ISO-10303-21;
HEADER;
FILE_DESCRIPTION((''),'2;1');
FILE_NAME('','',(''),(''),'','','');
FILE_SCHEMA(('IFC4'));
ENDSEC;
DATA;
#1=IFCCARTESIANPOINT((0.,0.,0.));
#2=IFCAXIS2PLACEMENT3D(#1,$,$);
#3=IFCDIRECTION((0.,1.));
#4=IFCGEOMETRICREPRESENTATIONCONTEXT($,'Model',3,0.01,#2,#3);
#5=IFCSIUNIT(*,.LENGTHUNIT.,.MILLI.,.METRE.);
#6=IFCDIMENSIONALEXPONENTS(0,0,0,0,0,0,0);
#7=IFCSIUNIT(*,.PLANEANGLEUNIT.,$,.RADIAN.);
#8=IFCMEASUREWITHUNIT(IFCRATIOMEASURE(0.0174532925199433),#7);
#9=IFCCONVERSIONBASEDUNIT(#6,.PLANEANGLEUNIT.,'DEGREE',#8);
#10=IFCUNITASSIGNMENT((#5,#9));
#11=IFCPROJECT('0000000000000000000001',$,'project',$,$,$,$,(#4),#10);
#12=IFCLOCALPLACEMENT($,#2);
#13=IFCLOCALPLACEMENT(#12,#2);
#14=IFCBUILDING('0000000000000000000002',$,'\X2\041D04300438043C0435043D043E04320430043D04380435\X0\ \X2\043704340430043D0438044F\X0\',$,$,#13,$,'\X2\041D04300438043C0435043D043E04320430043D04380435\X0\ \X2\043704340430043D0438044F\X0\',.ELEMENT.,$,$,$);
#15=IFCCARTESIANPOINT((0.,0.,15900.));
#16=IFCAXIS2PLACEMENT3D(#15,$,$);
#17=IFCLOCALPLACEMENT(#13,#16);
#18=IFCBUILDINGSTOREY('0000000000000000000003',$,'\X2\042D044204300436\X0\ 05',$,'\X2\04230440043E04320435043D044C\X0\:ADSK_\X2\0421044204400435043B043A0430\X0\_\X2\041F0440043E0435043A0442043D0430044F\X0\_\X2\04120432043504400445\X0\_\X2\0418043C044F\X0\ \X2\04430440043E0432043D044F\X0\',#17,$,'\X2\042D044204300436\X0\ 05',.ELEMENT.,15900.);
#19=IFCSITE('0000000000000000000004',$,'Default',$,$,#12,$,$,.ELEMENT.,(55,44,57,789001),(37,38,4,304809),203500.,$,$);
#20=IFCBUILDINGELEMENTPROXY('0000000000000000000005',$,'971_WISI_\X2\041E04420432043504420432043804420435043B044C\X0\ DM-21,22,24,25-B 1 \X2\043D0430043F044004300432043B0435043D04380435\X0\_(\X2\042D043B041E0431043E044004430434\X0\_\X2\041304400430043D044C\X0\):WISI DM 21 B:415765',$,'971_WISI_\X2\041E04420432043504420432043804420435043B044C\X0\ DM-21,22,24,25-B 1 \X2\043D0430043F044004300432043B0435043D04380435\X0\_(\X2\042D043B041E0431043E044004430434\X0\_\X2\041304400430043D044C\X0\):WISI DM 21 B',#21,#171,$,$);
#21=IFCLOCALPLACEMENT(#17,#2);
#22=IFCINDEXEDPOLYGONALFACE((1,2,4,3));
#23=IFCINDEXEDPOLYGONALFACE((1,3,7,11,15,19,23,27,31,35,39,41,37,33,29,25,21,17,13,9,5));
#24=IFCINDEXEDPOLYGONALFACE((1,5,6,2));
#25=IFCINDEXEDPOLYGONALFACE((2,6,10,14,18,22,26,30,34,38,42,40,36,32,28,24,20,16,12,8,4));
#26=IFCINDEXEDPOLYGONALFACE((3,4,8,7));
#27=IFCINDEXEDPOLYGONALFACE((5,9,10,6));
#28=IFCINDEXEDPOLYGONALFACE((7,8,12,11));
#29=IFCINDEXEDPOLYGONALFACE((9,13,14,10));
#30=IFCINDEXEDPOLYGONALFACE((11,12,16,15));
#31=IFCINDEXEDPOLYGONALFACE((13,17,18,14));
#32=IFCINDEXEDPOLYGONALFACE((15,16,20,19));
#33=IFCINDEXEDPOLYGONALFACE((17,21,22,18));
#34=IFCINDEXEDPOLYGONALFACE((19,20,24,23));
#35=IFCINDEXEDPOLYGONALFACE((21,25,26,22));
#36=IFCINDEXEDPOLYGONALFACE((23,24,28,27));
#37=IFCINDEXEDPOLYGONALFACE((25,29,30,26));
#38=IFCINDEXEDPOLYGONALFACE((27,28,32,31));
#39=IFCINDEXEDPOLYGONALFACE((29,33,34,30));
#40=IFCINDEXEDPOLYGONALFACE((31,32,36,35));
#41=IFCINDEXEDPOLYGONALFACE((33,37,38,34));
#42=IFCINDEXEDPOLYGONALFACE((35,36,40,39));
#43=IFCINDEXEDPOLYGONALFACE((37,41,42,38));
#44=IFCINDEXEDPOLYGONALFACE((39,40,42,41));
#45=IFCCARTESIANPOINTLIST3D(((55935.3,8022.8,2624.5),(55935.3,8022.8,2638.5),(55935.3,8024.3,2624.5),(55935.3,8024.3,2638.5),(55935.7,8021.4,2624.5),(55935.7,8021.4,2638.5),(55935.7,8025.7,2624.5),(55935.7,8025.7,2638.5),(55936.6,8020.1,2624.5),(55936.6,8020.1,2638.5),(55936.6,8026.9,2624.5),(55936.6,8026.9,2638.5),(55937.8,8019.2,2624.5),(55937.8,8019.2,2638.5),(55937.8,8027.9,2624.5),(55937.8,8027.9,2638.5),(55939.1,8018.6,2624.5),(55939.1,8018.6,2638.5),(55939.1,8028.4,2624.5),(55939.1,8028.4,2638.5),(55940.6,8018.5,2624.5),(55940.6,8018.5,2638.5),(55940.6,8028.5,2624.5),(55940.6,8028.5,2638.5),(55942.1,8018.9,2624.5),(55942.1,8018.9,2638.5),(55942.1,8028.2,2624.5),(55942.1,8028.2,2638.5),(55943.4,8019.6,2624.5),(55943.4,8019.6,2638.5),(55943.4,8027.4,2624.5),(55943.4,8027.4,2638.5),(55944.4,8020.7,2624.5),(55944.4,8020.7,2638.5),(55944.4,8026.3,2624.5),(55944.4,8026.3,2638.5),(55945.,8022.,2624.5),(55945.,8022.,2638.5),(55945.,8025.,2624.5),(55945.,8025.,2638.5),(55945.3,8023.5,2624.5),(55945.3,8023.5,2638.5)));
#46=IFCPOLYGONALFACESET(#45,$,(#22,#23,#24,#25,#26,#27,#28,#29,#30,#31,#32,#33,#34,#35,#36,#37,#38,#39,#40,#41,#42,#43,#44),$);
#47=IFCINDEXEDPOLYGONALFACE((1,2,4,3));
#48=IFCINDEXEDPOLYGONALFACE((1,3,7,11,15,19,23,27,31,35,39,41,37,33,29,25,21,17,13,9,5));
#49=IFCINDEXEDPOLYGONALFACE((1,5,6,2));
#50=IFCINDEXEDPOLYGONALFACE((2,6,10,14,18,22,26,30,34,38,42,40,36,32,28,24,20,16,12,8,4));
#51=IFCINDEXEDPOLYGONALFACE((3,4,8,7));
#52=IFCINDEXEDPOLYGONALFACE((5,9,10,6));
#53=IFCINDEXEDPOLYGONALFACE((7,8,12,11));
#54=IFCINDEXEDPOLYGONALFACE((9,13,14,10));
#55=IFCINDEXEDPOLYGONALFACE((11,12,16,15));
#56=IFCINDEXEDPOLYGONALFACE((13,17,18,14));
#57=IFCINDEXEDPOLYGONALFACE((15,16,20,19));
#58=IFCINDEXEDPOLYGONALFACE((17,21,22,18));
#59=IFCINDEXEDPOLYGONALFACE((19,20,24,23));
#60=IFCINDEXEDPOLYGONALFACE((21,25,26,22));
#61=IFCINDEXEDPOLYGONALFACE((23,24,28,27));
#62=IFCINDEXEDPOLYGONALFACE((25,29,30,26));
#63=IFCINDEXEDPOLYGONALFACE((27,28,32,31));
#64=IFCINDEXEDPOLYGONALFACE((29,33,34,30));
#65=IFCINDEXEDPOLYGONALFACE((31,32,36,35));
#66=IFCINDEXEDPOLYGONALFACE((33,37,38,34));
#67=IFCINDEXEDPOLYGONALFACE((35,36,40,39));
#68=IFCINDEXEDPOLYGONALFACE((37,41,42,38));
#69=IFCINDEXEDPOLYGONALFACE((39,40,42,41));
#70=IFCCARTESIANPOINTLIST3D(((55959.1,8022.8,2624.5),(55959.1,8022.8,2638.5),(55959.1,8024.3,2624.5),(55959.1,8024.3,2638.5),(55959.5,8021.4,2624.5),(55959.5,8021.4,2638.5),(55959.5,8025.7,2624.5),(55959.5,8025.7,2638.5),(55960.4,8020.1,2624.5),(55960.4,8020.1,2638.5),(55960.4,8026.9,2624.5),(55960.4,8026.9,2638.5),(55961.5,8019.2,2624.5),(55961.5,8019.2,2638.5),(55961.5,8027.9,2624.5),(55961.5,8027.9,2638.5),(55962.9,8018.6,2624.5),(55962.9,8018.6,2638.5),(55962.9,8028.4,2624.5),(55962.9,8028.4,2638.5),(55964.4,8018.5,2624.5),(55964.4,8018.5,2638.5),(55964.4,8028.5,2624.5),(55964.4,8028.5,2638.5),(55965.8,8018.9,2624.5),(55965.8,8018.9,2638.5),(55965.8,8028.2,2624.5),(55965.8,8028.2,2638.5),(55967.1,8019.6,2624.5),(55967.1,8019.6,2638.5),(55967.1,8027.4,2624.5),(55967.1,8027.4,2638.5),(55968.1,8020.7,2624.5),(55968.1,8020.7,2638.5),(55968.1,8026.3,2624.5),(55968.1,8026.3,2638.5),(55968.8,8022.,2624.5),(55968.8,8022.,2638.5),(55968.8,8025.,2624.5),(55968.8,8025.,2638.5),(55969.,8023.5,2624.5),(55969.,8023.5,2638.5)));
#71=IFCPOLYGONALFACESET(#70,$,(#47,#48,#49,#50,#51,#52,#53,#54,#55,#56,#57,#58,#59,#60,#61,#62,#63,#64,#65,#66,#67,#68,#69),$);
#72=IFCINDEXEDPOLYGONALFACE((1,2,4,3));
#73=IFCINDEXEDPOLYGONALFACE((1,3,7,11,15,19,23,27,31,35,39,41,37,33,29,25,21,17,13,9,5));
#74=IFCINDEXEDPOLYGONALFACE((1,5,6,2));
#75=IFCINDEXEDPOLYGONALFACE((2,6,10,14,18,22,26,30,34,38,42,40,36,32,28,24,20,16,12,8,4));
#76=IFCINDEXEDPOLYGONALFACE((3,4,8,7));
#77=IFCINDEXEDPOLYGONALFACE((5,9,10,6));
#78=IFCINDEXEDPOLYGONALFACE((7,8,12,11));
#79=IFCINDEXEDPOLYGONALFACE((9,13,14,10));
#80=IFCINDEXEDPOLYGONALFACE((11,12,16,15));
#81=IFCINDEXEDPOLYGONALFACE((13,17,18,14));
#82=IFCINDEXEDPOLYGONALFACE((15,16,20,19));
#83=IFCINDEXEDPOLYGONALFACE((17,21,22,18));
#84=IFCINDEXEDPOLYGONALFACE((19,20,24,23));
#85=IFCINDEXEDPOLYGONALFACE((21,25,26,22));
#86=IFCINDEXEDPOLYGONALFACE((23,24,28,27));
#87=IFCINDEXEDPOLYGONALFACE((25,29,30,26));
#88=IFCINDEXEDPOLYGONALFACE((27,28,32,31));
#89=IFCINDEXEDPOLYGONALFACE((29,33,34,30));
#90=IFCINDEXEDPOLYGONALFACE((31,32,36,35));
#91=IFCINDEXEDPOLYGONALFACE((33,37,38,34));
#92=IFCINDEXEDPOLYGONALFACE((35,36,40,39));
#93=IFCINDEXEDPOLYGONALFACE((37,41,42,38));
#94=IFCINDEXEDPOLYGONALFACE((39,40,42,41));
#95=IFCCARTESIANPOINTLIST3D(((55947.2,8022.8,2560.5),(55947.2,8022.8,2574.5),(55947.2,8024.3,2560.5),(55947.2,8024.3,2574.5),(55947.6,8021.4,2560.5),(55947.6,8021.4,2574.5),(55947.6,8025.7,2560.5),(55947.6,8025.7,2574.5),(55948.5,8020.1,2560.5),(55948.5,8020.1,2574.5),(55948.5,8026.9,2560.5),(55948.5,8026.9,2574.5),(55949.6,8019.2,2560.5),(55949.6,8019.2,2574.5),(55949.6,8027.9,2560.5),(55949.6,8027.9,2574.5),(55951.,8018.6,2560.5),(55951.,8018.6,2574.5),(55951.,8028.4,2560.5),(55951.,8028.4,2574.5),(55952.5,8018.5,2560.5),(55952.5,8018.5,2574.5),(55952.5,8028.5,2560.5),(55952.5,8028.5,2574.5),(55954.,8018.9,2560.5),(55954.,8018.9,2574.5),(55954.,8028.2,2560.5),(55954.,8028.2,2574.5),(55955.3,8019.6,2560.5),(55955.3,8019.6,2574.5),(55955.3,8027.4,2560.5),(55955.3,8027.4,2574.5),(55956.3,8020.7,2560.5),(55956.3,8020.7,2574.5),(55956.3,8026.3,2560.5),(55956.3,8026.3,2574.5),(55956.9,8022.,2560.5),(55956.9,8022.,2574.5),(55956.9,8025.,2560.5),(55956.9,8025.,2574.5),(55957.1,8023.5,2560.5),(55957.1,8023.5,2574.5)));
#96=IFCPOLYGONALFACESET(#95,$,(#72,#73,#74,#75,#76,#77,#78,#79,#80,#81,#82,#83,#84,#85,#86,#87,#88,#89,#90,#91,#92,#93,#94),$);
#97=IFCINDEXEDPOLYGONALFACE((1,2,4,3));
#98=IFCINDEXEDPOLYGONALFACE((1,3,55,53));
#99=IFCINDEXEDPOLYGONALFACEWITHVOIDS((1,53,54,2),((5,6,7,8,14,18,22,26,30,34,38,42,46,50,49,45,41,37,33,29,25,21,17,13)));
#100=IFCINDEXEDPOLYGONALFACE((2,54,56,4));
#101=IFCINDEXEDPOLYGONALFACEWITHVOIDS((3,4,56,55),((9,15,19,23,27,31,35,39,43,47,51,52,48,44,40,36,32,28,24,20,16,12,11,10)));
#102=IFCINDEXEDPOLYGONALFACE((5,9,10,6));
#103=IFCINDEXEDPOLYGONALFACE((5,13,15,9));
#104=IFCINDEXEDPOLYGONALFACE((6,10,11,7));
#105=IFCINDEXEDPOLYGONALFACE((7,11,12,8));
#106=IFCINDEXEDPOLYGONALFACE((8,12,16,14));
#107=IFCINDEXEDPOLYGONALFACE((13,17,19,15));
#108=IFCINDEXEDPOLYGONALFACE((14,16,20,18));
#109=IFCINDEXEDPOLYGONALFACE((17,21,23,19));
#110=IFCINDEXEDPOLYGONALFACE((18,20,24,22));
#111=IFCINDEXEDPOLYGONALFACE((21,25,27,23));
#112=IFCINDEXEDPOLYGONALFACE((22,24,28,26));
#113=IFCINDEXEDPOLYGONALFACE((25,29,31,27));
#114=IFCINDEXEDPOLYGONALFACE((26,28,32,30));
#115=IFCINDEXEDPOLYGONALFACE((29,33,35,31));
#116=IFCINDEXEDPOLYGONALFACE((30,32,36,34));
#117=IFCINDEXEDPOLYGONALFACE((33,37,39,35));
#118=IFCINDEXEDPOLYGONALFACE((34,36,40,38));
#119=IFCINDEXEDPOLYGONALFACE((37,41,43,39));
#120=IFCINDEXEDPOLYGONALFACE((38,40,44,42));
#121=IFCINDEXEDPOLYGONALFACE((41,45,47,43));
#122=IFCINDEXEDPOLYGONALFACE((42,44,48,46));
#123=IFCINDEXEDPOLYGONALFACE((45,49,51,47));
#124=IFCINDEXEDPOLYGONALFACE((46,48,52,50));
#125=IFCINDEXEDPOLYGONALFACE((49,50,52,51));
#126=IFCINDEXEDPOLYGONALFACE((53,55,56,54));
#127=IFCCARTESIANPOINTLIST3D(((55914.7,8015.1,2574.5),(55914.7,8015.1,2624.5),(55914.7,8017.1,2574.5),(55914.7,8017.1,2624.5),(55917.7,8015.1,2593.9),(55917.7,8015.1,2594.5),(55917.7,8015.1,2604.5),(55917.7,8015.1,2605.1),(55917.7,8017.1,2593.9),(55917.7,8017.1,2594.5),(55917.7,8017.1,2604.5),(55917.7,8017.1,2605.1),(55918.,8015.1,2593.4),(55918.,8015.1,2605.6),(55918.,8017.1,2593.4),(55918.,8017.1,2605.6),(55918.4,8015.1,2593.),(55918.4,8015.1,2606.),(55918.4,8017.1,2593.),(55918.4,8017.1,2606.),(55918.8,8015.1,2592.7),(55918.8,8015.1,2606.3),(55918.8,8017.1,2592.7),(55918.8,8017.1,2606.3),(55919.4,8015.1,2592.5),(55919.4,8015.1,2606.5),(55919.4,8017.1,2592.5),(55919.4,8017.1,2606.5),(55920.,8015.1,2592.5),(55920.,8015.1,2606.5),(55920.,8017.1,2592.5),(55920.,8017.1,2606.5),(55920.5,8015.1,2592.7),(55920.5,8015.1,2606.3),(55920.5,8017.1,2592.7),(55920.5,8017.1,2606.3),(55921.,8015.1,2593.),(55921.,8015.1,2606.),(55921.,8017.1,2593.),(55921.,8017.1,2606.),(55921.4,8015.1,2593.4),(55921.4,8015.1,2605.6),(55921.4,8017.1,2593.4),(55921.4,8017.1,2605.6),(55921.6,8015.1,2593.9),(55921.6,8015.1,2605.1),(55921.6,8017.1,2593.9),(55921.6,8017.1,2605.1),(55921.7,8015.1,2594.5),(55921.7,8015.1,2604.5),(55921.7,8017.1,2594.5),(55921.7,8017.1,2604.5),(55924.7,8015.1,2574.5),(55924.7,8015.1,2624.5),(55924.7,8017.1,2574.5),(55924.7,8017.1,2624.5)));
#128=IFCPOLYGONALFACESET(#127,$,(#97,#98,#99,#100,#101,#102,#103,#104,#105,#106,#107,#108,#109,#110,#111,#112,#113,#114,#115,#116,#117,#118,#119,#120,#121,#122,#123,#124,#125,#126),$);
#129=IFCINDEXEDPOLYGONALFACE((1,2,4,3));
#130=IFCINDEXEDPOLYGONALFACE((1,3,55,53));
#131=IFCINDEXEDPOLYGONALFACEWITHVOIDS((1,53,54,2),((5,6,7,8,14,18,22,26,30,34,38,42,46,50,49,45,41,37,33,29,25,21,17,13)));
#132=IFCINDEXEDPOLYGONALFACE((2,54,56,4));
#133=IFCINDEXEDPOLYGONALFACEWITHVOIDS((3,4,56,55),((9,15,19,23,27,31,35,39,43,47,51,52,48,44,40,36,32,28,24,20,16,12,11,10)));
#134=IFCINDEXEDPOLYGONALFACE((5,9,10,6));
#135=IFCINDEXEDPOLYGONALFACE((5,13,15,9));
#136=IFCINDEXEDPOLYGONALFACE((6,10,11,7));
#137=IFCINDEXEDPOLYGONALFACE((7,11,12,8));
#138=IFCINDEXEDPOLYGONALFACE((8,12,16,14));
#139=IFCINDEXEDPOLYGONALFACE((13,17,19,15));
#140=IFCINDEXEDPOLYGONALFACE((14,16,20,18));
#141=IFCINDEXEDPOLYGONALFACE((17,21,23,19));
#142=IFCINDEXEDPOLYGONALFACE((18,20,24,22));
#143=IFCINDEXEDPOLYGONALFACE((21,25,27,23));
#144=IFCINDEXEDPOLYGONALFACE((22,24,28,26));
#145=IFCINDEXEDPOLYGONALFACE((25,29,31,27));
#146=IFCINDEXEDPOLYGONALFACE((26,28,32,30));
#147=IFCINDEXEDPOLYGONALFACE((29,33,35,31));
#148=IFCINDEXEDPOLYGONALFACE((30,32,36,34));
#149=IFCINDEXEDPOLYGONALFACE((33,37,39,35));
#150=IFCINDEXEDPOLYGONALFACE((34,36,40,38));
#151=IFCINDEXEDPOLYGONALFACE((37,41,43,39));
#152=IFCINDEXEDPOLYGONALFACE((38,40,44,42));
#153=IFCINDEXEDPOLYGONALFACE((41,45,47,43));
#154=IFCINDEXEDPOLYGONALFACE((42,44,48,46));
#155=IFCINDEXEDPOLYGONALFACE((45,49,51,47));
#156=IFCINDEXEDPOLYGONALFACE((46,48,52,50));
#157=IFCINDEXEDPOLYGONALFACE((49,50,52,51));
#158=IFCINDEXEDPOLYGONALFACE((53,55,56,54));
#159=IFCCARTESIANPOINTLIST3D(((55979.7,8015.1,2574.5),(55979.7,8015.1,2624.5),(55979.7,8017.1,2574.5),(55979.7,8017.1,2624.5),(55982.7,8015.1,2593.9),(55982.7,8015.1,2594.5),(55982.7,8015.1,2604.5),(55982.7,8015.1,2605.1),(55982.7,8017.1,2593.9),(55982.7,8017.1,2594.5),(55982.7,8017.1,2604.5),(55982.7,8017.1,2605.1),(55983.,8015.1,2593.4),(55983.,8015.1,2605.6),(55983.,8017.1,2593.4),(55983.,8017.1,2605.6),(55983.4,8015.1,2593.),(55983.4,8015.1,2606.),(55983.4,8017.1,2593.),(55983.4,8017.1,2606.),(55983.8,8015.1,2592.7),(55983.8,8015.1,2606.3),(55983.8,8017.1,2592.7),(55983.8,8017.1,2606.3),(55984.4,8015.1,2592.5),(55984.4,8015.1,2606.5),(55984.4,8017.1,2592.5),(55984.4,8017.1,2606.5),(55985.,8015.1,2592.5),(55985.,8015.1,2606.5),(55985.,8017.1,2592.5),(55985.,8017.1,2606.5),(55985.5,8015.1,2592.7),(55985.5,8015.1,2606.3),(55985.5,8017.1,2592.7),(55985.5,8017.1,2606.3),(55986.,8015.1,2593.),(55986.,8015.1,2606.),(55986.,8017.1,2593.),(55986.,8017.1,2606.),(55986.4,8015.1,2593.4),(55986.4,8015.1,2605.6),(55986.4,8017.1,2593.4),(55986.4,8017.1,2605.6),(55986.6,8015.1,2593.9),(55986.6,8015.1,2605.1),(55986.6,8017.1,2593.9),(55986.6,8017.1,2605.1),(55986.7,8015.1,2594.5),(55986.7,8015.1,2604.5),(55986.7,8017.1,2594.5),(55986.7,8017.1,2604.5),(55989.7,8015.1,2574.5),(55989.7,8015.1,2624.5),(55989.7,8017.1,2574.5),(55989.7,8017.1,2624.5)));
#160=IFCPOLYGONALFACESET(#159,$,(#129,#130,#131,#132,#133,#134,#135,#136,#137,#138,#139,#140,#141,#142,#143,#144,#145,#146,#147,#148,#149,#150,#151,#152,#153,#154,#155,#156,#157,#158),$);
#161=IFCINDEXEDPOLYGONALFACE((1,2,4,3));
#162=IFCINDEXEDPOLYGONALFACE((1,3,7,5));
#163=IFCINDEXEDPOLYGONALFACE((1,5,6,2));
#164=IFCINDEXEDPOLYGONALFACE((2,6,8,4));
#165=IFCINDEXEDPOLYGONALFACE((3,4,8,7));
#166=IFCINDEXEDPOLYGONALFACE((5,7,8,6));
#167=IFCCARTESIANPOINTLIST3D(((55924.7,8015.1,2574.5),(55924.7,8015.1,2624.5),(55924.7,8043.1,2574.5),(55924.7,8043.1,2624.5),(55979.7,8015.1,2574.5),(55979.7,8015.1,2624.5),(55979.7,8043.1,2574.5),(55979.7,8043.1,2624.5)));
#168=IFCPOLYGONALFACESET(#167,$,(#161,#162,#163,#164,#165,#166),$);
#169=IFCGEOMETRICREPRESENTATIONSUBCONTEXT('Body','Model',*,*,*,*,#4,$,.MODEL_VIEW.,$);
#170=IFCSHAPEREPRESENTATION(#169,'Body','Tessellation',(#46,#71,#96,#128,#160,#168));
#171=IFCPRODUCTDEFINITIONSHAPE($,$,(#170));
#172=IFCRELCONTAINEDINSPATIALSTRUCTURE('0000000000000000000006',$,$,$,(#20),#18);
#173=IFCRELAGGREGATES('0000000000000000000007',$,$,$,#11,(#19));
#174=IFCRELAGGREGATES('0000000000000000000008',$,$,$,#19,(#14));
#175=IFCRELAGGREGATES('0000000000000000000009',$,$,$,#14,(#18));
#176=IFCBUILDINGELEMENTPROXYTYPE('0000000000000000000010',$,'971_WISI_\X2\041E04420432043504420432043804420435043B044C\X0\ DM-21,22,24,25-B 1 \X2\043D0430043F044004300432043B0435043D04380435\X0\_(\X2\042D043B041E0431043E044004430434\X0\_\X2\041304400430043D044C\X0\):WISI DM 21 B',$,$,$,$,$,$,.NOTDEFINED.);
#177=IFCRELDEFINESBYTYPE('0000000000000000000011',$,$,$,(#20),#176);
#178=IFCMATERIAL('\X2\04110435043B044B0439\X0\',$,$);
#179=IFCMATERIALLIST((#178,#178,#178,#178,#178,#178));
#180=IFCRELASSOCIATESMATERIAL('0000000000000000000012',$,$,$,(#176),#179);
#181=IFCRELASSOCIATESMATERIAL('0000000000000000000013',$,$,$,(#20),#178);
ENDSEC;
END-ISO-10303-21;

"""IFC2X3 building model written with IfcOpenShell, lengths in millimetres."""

from ifc_helpers import new_model, entity, si_unit, converted_unit, direction, frame, frame_2d, origin, place, context, subcontext, project, spatial, polyline, circle_curve, parameter, trimmed, segment, composite_curve, rectangle, circle, outline, extrude, source, transform, mapped, material, material_list, type_object, type_shapes, element, save


model = new_model("IFC2X3")

# Units and contexts
model_context = context("Model", 3, precision=0.01, world=origin(), true_north=direction((0.0, 1.0)))
body_context = subcontext(model_context, "Body", "Model", "MODEL_VIEW")
ifc_project = project(units=[si_unit("LENGTHUNIT", "METRE", prefix="MILLI"), converted_unit("PLANEANGLEUNIT", "DEGREE", entity("IfcRatioMeasure", 0.0174532925199433), si_unit("PLANEANGLEUNIT", "RADIAN"), dimensions=[0, 0, 0, 0, 0, 0, 0])], contexts=[model_context])

# Site, building, storey
site_placement = place(None, frame((0.0, 0.0, 0.0)))
site = spatial("IfcSite", under=ifc_project, at=site_placement, Name="Default", CompositionType="ELEMENT", RefLatitude=(55, 44, 57, 789001), RefLongitude=(37, 38, 4, 304809), RefElevation=203500.0)
building_placement = place(site_placement, origin())
building = spatial("IfcBuilding", under=site, at=building_placement, Name="Наименование здания", LongName="Наименование здания", CompositionType="ELEMENT")
storey_placement = place(building_placement, frame((0.0, 0.0, 15900.0)))
storey = spatial("IfcBuildingStorey", under=building, at=storey_placement, Name="Этаж 05", ObjectType="Уровень:ADSK_Стрелка_Проектная_Вверх_Имя уровня", LongName="Этаж 05", CompositionType="ELEMENT", Elevation=15900.0)

# Building element proxy
ifc_material = material(Name="Белый")
ifc_material_list = material_list([ifc_material, ifc_material, ifc_material, ifc_material, ifc_material, ifc_material])
building_element_proxy_type = type_object("IfcBuildingElementProxyType", Name="971_WISI_Ответвитель DM-21,22,24,25-B 1 направление_(ЭлОборуд_Грань):WISI DM 21 B", PredefinedType="NOTDEFINED", material=ifc_material_list)
shared_shape = source(origin(), body_context, "Body", "SweptSolid", [
    extrude(circle(Radius=5.0, at=frame_2d((0.0, 0.0), x_axis=(1.0, 0.0))), frame((11.9, 25.0, 8.4), z_axis=(0.0, 1.0, 0.0), x_axis=(-1.0, 0.0, 0.0)), (0.0, 0.0, 1.0), 14.0),
    extrude(circle(Radius=5.0, at=frame_2d((0.0, 0.0), x_axis=(1.0, 0.0))), frame((-11.8, 25.0, 8.4), z_axis=(0.0, 1.0, 0.0), x_axis=(-1.0, 0.0, 0.0)), (0.0, 0.0, 1.0), 14.0),
    extrude(circle(Radius=5.0, at=frame_2d((0.0, 0.0), x_axis=(1.0, 0.0))), frame((0.0, -39.0, 8.4), z_axis=(0.0, 1.0, 0.0), x_axis=(-1.0, 0.0, 0.0)), (0.0, 0.0, 1.0), 14.0),
    extrude(outline(polyline([(-5.0, -25.0), (5.0, -25.0), (5.0, 25.0), (-5.0, 25.0), (-5.0, -25.0)]), holes=[composite_curve([segment(polyline([(2.0, 5.0), (2.0, -5.0)]), True, "CONTINUOUS"), segment(trimmed(circle_curve(frame_2d((0.0, -5.0), x_axis=(-1.0, 0.0)), 2.0), [parameter(0.0)], [parameter(180.0)], True, "PARAMETER"), False, "CONTINUOUS"), segment(polyline([(-2.0, -5.0), (-2.0, 5.0)]), True, "CONTINUOUS"), segment(trimmed(circle_curve(frame_2d((0.0, 5.0), x_axis=(-1.0, 0.0)), 2.0), [parameter(180.0)], [parameter(0.0)], True, "PARAMETER"), False, "CONTINUOUS")], self_intersect=False)]), frame((32.5, 0.0, 0.0), z_axis=(0.0, 0.0, 1.0), x_axis=(-1.0, 0.0, 0.0)), (0.0, 0.0, 1.0), 2.0),
    extrude(outline(polyline([(-5.0, -25.0), (5.0, -25.0), (5.0, 25.0), (-5.0, 25.0), (-5.0, -25.0)]), holes=[composite_curve([segment(polyline([(-2.0, -5.0), (-2.0, 5.0)]), True, "CONTINUOUS"), segment(trimmed(circle_curve(frame_2d((0.0, 5.0), x_axis=(-1.0, 0.0)), 2.0), [parameter(180.0)], [parameter(0.0)], True, "PARAMETER"), False, "CONTINUOUS"), segment(polyline([(2.0, 5.0), (2.0, -5.0)]), True, "CONTINUOUS"), segment(trimmed(circle_curve(frame_2d((0.0, -5.0), x_axis=(-1.0, 0.0)), 2.0), [parameter(0.0)], [parameter(180.0)], True, "PARAMETER"), False, "CONTINUOUS")], self_intersect=False)]), frame((-32.5, 0.0, 0.0), z_axis=(0.0, 0.0, 1.0), x_axis=(-1.0, 0.0, 0.0)), (0.0, 0.0, 1.0), 2.0),
    extrude(rectangle(XDim=55.0, YDim=50.0, at=frame_2d((0.0, 0.0), x_axis=(1.0, 0.0))), frame((0.0, 0.0, 0.0), z_axis=(0.0, 0.0, 1.0), x_axis=(-1.0, 0.0, 0.0)), (0.0, 0.0, 1.0), 28.0),
])
type_shapes(building_element_proxy_type, [shared_shape])
for number, where, z_axis, x_axis, name in (
    (1, (55952.2, 8015.1, 2599.5), (0.0, 1.0, 0.0), (-1.0, 0.0, 0.0), "971_WISI_Ответвитель DM-21,22,24,25-B 1 направление_(ЭлОборуд_Грань):WISI DM 21 B:415765"),
):
    element("IfcBuildingElementProxy", number, at=place(storey_placement, frame(where, z_axis=z_axis, x_axis=x_axis)), inside=storey, type_object=building_element_proxy_type, material=ifc_material, Name=name, ObjectType="971_WISI_Ответвитель DM-21,22,24,25-B 1 направление_(ЭлОборуд_Грань):WISI DM 21 B", context=body_context, shape_type="MappedRepresentation", body=[
        mapped(shared_shape, transform((0.0, 0.0, 0.0), scale=1.0)),
    ])

save(model, "model.ifc")
